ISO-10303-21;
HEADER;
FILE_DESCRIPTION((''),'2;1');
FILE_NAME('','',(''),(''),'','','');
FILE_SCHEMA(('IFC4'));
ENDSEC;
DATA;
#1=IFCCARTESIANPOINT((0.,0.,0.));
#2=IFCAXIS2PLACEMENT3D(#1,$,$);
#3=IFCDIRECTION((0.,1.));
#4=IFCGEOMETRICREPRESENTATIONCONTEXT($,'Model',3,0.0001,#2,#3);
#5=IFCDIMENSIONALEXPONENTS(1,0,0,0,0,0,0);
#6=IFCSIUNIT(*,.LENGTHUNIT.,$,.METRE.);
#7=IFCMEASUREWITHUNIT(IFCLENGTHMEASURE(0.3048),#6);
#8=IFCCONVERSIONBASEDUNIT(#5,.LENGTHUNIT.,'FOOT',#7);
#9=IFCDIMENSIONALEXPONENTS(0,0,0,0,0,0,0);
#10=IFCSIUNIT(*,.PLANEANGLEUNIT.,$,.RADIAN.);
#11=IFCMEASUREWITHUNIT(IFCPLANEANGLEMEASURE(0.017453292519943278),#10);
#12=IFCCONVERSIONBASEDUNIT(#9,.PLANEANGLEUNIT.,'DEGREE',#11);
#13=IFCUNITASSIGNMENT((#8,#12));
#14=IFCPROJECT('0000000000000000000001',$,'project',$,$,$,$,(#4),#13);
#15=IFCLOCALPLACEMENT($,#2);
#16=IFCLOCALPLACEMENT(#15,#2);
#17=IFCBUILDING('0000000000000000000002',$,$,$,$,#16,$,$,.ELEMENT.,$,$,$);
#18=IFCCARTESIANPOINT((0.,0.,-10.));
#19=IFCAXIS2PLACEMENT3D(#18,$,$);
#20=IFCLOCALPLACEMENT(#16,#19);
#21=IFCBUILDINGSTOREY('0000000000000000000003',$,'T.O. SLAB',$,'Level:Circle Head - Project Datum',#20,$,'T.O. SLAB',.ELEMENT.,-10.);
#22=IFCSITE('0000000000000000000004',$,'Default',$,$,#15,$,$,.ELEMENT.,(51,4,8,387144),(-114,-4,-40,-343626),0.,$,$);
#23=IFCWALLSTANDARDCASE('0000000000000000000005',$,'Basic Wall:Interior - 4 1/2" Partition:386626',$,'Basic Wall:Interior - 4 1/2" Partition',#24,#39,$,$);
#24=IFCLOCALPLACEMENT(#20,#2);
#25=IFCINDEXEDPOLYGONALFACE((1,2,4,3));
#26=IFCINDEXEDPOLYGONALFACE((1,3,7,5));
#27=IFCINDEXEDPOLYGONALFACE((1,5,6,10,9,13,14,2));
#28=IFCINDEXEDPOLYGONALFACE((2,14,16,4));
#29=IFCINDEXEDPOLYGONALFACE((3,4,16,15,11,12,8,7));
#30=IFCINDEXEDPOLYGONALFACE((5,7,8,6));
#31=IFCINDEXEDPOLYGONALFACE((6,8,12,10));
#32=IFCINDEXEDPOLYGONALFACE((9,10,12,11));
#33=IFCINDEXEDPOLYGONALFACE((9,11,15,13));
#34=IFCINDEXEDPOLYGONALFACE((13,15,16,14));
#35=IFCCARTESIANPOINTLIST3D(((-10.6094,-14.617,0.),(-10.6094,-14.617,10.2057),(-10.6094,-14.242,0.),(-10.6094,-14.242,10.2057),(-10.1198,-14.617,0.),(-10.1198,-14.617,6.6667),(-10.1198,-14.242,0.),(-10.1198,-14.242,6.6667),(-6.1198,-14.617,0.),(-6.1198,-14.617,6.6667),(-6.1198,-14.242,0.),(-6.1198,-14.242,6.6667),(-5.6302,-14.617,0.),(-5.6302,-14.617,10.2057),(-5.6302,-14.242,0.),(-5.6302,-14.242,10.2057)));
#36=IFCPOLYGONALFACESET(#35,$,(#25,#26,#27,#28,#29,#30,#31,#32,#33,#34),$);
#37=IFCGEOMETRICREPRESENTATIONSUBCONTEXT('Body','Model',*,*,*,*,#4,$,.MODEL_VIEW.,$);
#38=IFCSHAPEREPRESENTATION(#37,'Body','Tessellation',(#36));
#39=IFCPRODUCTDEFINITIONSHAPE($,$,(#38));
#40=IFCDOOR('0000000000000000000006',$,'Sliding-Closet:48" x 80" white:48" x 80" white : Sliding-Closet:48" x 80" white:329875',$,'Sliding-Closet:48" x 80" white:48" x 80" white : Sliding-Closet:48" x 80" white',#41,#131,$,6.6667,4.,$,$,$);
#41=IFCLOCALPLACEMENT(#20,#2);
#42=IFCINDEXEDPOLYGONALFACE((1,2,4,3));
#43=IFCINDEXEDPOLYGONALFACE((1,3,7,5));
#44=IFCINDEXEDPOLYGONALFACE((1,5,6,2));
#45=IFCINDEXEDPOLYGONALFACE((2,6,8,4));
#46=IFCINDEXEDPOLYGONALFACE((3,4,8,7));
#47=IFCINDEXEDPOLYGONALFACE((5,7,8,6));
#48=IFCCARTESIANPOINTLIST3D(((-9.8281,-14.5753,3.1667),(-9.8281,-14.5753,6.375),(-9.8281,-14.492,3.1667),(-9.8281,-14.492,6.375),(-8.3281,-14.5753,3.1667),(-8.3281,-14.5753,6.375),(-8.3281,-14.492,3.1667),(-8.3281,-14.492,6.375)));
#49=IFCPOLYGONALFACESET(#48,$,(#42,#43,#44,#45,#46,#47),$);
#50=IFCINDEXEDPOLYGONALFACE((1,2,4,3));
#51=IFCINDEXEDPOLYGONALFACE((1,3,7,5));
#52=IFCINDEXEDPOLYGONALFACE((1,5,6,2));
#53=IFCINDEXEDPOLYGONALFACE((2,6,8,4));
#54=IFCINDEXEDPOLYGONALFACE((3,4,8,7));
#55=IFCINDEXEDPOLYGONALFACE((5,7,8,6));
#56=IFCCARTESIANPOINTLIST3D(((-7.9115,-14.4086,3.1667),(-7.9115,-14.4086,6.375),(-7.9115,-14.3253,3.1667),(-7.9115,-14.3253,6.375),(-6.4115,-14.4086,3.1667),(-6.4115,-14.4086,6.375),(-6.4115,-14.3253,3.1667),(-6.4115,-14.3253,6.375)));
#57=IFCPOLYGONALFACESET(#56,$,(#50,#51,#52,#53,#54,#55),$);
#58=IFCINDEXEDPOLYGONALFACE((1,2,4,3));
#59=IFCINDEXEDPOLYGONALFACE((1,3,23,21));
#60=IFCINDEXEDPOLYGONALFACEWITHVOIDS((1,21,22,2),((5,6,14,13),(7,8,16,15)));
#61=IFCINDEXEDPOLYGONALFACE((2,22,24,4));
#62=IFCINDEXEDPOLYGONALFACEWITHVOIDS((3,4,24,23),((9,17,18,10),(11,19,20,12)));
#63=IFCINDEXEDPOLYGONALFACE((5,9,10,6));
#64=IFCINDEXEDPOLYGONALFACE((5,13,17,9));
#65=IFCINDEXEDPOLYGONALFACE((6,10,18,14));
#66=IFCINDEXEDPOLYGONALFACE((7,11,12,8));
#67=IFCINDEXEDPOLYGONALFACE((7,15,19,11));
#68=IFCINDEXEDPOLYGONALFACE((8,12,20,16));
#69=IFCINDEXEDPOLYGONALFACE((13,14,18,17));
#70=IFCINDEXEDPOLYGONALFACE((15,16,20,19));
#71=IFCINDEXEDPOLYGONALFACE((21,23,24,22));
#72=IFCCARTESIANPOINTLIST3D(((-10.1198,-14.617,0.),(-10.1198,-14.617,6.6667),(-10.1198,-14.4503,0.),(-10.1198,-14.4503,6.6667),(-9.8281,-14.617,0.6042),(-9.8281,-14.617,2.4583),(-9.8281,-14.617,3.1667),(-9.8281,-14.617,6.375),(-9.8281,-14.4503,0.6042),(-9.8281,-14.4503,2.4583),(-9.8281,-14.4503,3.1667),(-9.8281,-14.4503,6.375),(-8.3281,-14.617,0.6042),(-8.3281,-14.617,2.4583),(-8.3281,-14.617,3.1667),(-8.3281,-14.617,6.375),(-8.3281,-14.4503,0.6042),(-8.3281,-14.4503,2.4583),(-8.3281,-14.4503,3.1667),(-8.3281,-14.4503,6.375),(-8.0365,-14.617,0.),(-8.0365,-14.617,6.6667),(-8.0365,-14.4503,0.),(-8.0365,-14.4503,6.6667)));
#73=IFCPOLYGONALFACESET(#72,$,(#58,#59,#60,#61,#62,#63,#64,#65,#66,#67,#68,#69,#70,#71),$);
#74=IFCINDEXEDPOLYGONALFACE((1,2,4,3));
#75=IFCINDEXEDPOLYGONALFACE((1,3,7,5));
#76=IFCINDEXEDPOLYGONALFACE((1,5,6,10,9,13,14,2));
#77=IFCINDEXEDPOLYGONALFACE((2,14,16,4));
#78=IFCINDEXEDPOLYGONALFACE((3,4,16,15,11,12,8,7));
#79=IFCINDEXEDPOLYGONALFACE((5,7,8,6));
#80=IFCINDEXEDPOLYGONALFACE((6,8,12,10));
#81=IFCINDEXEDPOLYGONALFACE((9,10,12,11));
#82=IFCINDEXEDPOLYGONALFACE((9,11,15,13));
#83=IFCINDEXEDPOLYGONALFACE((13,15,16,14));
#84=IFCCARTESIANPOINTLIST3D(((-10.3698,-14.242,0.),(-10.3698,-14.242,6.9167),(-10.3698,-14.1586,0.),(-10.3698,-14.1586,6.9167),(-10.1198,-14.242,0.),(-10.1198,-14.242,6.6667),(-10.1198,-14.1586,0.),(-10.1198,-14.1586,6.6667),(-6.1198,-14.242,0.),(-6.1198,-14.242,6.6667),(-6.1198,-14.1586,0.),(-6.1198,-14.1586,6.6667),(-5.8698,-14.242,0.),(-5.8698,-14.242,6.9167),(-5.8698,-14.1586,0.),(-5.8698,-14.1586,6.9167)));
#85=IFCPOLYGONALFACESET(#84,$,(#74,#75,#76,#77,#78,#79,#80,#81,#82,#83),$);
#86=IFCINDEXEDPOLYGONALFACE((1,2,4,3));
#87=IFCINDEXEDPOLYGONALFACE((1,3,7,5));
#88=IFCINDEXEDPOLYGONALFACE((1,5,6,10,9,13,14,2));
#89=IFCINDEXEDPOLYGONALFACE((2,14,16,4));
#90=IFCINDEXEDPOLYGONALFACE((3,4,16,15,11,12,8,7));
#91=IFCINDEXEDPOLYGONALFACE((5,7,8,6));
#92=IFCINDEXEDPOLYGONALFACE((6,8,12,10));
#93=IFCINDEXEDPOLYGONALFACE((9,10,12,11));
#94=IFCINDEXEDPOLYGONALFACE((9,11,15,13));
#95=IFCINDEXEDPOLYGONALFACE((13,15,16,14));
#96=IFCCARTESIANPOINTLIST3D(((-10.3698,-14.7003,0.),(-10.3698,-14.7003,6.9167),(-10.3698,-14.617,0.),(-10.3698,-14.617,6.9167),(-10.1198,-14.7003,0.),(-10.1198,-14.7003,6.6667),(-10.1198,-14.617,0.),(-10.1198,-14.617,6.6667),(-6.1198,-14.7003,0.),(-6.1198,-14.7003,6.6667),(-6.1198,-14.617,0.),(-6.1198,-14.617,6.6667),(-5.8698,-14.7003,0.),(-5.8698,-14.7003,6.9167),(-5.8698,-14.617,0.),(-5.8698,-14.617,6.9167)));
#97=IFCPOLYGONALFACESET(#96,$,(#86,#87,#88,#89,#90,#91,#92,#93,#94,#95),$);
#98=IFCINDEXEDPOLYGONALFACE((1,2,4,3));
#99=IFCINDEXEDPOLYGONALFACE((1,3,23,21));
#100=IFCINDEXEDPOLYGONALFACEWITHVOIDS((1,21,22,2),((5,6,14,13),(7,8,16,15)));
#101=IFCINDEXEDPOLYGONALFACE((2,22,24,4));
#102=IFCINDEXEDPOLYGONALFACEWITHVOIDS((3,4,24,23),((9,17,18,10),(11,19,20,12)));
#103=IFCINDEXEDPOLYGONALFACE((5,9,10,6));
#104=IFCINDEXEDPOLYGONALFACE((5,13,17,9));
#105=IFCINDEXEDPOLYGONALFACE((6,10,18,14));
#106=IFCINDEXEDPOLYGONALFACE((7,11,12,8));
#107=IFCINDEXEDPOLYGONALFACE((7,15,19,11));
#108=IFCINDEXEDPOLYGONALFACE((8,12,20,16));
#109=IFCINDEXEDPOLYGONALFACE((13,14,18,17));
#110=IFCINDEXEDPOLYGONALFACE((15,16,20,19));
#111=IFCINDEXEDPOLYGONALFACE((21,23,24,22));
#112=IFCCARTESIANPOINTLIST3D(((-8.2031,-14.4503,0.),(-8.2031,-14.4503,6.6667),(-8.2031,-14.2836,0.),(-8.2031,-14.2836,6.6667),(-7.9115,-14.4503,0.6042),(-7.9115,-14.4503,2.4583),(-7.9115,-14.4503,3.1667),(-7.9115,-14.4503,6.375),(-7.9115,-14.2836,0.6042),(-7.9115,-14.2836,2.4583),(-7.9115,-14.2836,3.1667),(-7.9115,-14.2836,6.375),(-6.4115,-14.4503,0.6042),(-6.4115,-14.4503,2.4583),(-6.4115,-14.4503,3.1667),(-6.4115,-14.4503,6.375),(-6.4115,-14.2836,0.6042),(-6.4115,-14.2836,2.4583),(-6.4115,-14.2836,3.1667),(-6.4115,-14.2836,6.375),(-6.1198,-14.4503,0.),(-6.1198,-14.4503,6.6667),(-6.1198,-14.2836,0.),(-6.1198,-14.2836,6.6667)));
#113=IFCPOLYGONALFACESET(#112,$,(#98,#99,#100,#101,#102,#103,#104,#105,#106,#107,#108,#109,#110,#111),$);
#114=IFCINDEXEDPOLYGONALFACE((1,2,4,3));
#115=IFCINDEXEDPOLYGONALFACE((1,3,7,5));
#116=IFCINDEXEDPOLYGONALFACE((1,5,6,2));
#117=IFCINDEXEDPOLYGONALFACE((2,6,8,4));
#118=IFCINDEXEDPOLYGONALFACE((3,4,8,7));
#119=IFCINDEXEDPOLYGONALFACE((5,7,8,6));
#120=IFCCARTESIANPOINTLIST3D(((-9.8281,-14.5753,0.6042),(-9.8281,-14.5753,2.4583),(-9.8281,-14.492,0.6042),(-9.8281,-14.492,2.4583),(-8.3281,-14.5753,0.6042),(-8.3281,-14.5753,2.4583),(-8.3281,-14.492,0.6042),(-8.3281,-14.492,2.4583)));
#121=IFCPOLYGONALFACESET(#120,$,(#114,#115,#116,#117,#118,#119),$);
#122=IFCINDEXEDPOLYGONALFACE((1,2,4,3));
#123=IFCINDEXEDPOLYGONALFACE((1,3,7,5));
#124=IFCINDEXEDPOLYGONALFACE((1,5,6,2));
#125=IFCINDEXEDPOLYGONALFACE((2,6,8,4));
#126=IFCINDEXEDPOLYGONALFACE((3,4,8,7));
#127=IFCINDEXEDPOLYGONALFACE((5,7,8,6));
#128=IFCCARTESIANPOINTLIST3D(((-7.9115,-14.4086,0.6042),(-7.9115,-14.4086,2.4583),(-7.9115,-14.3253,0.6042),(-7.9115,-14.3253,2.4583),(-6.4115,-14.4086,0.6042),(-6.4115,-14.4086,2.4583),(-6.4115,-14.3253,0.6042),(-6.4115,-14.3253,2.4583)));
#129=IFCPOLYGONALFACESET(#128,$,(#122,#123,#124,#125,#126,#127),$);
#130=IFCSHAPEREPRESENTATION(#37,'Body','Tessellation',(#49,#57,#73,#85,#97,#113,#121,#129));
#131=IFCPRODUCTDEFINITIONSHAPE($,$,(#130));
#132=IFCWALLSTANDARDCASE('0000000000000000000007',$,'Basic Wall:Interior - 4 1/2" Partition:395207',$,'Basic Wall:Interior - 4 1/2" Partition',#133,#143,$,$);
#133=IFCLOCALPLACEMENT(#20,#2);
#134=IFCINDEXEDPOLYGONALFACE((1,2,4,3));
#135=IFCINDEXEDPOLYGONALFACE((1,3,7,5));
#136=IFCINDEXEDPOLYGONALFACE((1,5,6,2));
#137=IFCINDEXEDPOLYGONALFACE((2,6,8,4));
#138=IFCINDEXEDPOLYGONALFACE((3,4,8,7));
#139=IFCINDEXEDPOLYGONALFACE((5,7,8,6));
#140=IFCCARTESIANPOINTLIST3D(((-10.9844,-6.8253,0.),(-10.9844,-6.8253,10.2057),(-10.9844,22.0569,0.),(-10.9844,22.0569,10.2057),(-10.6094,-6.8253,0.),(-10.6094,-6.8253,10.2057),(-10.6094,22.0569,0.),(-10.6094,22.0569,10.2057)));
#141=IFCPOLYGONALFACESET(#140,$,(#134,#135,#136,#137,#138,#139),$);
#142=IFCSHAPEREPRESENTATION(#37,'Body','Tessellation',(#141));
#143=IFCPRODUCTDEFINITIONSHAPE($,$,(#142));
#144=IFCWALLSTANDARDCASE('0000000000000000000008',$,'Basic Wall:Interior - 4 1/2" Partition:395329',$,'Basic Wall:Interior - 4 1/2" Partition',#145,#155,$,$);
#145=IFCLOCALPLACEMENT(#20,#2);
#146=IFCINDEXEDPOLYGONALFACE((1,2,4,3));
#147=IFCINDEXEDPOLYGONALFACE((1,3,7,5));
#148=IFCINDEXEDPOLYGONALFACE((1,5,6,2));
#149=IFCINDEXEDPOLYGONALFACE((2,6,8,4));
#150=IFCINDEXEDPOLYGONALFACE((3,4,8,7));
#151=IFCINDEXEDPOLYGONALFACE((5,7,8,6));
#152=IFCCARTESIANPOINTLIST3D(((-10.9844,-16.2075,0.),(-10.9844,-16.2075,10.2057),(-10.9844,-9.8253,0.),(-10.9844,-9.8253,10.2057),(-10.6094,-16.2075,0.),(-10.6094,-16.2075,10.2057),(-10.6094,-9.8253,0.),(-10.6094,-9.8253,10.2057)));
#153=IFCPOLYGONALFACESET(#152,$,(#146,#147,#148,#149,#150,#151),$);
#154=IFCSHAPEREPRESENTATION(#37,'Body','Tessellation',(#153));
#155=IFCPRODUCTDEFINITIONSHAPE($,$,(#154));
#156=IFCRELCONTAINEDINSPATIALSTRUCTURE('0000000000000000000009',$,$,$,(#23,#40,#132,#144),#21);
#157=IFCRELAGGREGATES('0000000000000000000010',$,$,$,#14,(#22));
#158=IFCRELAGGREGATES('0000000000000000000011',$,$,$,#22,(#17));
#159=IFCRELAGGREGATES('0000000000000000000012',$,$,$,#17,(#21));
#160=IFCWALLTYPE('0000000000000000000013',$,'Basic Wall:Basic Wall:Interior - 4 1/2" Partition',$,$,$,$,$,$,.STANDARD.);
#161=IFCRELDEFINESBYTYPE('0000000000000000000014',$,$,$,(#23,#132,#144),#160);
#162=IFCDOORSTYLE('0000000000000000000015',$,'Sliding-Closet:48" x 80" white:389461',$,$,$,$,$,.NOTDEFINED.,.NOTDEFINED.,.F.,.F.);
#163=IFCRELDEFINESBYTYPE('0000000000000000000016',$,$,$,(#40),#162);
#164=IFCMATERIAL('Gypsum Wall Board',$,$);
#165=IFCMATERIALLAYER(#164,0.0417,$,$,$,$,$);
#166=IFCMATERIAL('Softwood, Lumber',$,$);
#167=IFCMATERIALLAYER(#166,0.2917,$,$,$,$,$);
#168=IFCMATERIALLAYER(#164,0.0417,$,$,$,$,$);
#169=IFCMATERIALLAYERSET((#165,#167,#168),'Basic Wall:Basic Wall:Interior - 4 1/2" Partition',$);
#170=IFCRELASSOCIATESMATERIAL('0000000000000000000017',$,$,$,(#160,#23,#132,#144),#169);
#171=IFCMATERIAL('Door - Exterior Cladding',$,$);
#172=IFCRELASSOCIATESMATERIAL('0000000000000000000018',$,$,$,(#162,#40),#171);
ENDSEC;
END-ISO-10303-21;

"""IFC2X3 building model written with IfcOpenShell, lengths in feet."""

from ifc_helpers import new_model, entity, si_unit, converted_unit, direction, frame, frame_2d, origin, origin_2d_with_axis, place, context, subcontext, project, spatial, polyline, rectangle, outline, extrude, source, transform, mapped, material, layer, layer_set, layer_usage, type_object, type_shapes, element, fill, save


model = new_model("IFC2X3")

# Units and contexts
model_context = context("Model", 3, precision=0.0001, world=origin(), true_north=direction((0.0, 1.0)))
body_context = subcontext(model_context, "Body", "Model", "MODEL_VIEW")
ifc_project = project(units=[converted_unit("LENGTHUNIT", "FOOT", entity("IfcLengthMeasure", 0.3048), si_unit("LENGTHUNIT", "METRE"), dimensions=[1, 0, 0, 0, 0, 0, 0]), converted_unit("PLANEANGLEUNIT", "DEGREE", entity("IfcPlaneAngleMeasure", 0.017453292519943278), si_unit("PLANEANGLEUNIT", "RADIAN"), dimensions=[0, 0, 0, 0, 0, 0, 0])], contexts=[model_context])

# Site, building, storey
site_placement = place(None, origin())
site = spatial("IfcSite", under=ifc_project, at=site_placement, Name="Default", CompositionType="ELEMENT", RefLatitude=(51, 4, 8, 387144), RefLongitude=(-114, -4, -40, -343626), RefElevation=0.0)
building_placement = place(site_placement, origin())
building = spatial("IfcBuilding", under=site, at=building_placement, CompositionType="ELEMENT")
storey_placement = place(building_placement, frame((0.0, 0.0, -10.0)))
storey = spatial("IfcBuildingStorey", under=building, at=storey_placement, Name="T.O. SLAB", ObjectType="Level:Circle Head - Project Datum", LongName="T.O. SLAB", CompositionType="ELEMENT", Elevation=-10.0)

# Shared definitions
ifc_material_1 = material(Name="Gypsum Wall Board")
ifc_layer_1 = layer(ifc_material_1, 0.0417)
ifc_material_2 = material(Name="Softwood, Lumber")
ifc_layer_2 = layer(ifc_material_2, 0.2917)
ifc_layer_3 = layer(ifc_material_1, 0.0417)
ifc_layer_set_1 = layer_set([ifc_layer_1, ifc_layer_2, ifc_layer_3], Name="Basic Wall:Basic Wall:Interior - 4 1/2\" Partition")
wall_type_1 = type_object("IfcWallType", Name="Basic Wall:Basic Wall:Interior - 4 1/2\" Partition", PredefinedType="STANDARD", material=ifc_layer_set_1)

# Shared definitions
ifc_material_3 = material(Name="Door - Exterior Cladding")

# Wall, opening, door
ifc_layer_usage_1 = layer_usage(ifc_layer_set_1, "AXIS2", "NEGATIVE", 0.1875)
wall_1_placement = place(storey_placement, frame((-5.6302, -14.4295, 0.0), z_axis=(0.0, 0.0, 1.0), x_axis=(-1.0, 0.0, 0.0)))
wall_1 = element("IfcWallStandardCase", 1, at=wall_1_placement, inside=storey, type_object=wall_type_1, material=ifc_layer_usage_1, Name="Basic Wall:Interior - 4 1/2\" Partition:386626", ObjectType="Basic Wall:Interior - 4 1/2\" Partition", context=body_context, shape_type="SweptSolid", body=[
    extrude(rectangle(XDim=4.9792, YDim=0.375, at=frame_2d((2.4896, 0.0), x_axis=(1.0, 0.0))), origin(), (0.0, 0.0, 1.0), 10.2057),
])
opening_1_placement = place(wall_1_placement, frame((-5.6302, -14.4295, 0.0), z_axis=(0.0, 0.0, 1.0), x_axis=(-1.0, 0.0, 0.0)))
opening_1 = element("IfcOpeningElement", 2, at=opening_1_placement, cuts=wall_1, ObjectType="Opening", context=body_context, shape_type="SweptSolid", body=[
    extrude(rectangle(XDim=6.6667, YDim=4.0, at=frame_2d((0.0, 0.0), x_axis=(0.0, 1.0))), frame((-8.1198, -14.2382, 3.3333), z_axis=(0.0, -1.0, 0.0), x_axis=(1.0, 0.0, 0.0)), (0.0, 0.0, 1.0), 0.3825),
])
door_style_1 = type_object("IfcDoorStyle", Name="Sliding-Closet:48\" x 80\" white:389461", ConstructionType="NOTDEFINED", OperationType="NOTDEFINED", ParameterTakesPrecedence=False, Sizeable=False, material=ifc_material_3)
shared_shape_1 = source(origin(), body_context, "Body", "SweptSolid", [
    extrude(rectangle(XDim=0.0833, YDim=1.5, at=origin_2d_with_axis()), frame((2.9583, -0.0871, 3.1667), z_axis=(0.0, 0.0, 1.0), x_axis=(0.0, 1.0, 0.0)), (0.0, 0.0, 1.0), 3.2083),
    extrude(rectangle(XDim=0.0833, YDim=1.5, at=origin_2d_with_axis()), frame((1.0417, -0.2538, 3.1667), z_axis=(0.0, 0.0, 1.0), x_axis=(0.0, -1.0, 0.0)), (0.0, 0.0, 1.0), 3.2083),
    extrude(outline(polyline([(-3.3333, -1.0417), (3.3333, -1.0417), (3.3333, 1.0417), (-3.3333, 1.0417), (-3.3333, -1.0417)]), holes=[polyline([(-0.1667, -0.75), (-0.1667, 0.75), (3.0417, 0.75), (3.0417, -0.75), (-0.1667, -0.75)]), polyline([(-2.7292, -0.75), (-2.7292, 0.75), (-0.875, 0.75), (-0.875, -0.75), (-2.7292, -0.75)])]), frame((2.9583, -0.1704, 3.3333), z_axis=(0.0, 1.0, 0.0), x_axis=(0.0, 0.0, 1.0)), (0.0, 0.0, 1.0), 0.1667),
    extrude(outline(polyline([(-3.5208, -2.25), (3.3958, -2.25), (3.3958, -2.0), (-3.2708, -2.0), (-3.2708, 2.0), (3.3958, 2.0), (3.3958, 2.25), (-3.5208, 2.25), (-3.5208, -2.25)])), frame((2.0, -0.4621, 3.3958), z_axis=(0.0, 1.0, 0.0), x_axis=(0.0, 0.0, -1.0)), (0.0, 0.0, 1.0), 0.0833),
    extrude(outline(polyline([(2.0, -3.3958), (2.25, -3.3958), (2.25, 3.5208), (-2.25, 3.5208), (-2.25, -3.3958), (-2.0, -3.3958), (-2.0, 3.2708), (2.0, 3.2708), (2.0, -3.3958)])), frame((2.0, -0.0037, 3.3958), z_axis=(0.0, 1.0, 0.0), x_axis=(-1.0, 0.0, 0.0)), (0.0, 0.0, 1.0), 0.0833),
    extrude(outline(polyline([(-1.0417, -3.3333), (1.0417, -3.3333), (1.0417, 3.3333), (-1.0417, 3.3333), (-1.0417, -3.3333)]), holes=[polyline([(-0.75, 0.875), (-0.75, 2.7292), (0.75, 2.7292), (0.75, 0.875), (-0.75, 0.875)]), polyline([(-0.75, -3.0417), (-0.75, 0.1667), (0.75, 0.1667), (0.75, -3.0417), (-0.75, -3.0417)])]), frame((1.0417, -0.3371, 3.3333), z_axis=(0.0, 1.0, 0.0), x_axis=(1.0, 0.0, 0.0)), (0.0, 0.0, 1.0), 0.1667),
    extrude(rectangle(XDim=0.0833, YDim=1.5, at=origin_2d_with_axis()), frame((2.9583, -0.0871, 0.6042), z_axis=(0.0, 0.0, 1.0), x_axis=(0.0, 1.0, 0.0)), (0.0, 0.0, 1.0), 1.8542),
    extrude(rectangle(XDim=0.0833, YDim=1.5, at=origin_2d_with_axis()), frame((1.0417, -0.2538, 0.6042), z_axis=(0.0, 0.0, 1.0), x_axis=(0.0, -1.0, 0.0)), (0.0, 0.0, 1.0), 1.8542),
])
type_shapes(door_style_1, [shared_shape_1])
door_1_placement = place(opening_1_placement, frame((-6.1198, -14.6207, 0.0), z_axis=(0.0, 0.0, 1.0), x_axis=(-1.0, 0.0, 0.0)))
door_1 = element("IfcDoor", 3, at=door_1_placement, inside=storey, type_object=door_style_1, material=ifc_material_3, Name="Sliding-Closet:48\" x 80\" white:48\" x 80\" white : Sliding-Closet:48\" x 80\" white:329875", ObjectType="Sliding-Closet:48\" x 80\" white:48\" x 80\" white : Sliding-Closet:48\" x 80\" white", OverallHeight=6.6667, OverallWidth=4.0, context=body_context, shape_type="MappedRepresentation", body=[
    mapped(shared_shape_1, transform((0.0, 0.0, 0.0), scale=1.0)),
])
fill(opening_1, door_1)

# Walls
ifc_layer_usage_2 = layer_usage(ifc_layer_set_1, "AXIS2", "NEGATIVE", 0.1875)
wall_2_placement = place(storey_placement, frame((-10.7969, -6.8253, 0.0), z_axis=(0.0, 0.0, 1.0), x_axis=(0.0, 1.0, 0.0)))
element("IfcWallStandardCase", 4, at=wall_2_placement, inside=storey, type_object=wall_type_1, material=ifc_layer_usage_2, Name="Basic Wall:Interior - 4 1/2\" Partition:395207", ObjectType="Basic Wall:Interior - 4 1/2\" Partition", context=body_context, shape_type="SweptSolid", body=[
    extrude(rectangle(XDim=28.8822, YDim=0.375, at=frame_2d((14.4411, 0.0), x_axis=(-1.0, 0.0))), origin(), (0.0, 0.0, 1.0), 10.2057),
])
ifc_layer_usage_3 = layer_usage(ifc_layer_set_1, "AXIS2", "NEGATIVE", 0.1875)
wall_3_placement = place(storey_placement, frame((-10.7969, -16.2075, 0.0), z_axis=(0.0, 0.0, 1.0), x_axis=(0.0, 1.0, 0.0)))
element("IfcWallStandardCase", 5, at=wall_3_placement, inside=storey, type_object=wall_type_1, material=ifc_layer_usage_3, Name="Basic Wall:Interior - 4 1/2\" Partition:395329", ObjectType="Basic Wall:Interior - 4 1/2\" Partition", context=body_context, shape_type="SweptSolid", body=[
    extrude(rectangle(XDim=6.3822, YDim=0.375, at=frame_2d((3.1911, 0.0), x_axis=(-1.0, 0.0))), origin(), (0.0, 0.0, 1.0), 10.2057),
])

save(model, "model.ifc")
